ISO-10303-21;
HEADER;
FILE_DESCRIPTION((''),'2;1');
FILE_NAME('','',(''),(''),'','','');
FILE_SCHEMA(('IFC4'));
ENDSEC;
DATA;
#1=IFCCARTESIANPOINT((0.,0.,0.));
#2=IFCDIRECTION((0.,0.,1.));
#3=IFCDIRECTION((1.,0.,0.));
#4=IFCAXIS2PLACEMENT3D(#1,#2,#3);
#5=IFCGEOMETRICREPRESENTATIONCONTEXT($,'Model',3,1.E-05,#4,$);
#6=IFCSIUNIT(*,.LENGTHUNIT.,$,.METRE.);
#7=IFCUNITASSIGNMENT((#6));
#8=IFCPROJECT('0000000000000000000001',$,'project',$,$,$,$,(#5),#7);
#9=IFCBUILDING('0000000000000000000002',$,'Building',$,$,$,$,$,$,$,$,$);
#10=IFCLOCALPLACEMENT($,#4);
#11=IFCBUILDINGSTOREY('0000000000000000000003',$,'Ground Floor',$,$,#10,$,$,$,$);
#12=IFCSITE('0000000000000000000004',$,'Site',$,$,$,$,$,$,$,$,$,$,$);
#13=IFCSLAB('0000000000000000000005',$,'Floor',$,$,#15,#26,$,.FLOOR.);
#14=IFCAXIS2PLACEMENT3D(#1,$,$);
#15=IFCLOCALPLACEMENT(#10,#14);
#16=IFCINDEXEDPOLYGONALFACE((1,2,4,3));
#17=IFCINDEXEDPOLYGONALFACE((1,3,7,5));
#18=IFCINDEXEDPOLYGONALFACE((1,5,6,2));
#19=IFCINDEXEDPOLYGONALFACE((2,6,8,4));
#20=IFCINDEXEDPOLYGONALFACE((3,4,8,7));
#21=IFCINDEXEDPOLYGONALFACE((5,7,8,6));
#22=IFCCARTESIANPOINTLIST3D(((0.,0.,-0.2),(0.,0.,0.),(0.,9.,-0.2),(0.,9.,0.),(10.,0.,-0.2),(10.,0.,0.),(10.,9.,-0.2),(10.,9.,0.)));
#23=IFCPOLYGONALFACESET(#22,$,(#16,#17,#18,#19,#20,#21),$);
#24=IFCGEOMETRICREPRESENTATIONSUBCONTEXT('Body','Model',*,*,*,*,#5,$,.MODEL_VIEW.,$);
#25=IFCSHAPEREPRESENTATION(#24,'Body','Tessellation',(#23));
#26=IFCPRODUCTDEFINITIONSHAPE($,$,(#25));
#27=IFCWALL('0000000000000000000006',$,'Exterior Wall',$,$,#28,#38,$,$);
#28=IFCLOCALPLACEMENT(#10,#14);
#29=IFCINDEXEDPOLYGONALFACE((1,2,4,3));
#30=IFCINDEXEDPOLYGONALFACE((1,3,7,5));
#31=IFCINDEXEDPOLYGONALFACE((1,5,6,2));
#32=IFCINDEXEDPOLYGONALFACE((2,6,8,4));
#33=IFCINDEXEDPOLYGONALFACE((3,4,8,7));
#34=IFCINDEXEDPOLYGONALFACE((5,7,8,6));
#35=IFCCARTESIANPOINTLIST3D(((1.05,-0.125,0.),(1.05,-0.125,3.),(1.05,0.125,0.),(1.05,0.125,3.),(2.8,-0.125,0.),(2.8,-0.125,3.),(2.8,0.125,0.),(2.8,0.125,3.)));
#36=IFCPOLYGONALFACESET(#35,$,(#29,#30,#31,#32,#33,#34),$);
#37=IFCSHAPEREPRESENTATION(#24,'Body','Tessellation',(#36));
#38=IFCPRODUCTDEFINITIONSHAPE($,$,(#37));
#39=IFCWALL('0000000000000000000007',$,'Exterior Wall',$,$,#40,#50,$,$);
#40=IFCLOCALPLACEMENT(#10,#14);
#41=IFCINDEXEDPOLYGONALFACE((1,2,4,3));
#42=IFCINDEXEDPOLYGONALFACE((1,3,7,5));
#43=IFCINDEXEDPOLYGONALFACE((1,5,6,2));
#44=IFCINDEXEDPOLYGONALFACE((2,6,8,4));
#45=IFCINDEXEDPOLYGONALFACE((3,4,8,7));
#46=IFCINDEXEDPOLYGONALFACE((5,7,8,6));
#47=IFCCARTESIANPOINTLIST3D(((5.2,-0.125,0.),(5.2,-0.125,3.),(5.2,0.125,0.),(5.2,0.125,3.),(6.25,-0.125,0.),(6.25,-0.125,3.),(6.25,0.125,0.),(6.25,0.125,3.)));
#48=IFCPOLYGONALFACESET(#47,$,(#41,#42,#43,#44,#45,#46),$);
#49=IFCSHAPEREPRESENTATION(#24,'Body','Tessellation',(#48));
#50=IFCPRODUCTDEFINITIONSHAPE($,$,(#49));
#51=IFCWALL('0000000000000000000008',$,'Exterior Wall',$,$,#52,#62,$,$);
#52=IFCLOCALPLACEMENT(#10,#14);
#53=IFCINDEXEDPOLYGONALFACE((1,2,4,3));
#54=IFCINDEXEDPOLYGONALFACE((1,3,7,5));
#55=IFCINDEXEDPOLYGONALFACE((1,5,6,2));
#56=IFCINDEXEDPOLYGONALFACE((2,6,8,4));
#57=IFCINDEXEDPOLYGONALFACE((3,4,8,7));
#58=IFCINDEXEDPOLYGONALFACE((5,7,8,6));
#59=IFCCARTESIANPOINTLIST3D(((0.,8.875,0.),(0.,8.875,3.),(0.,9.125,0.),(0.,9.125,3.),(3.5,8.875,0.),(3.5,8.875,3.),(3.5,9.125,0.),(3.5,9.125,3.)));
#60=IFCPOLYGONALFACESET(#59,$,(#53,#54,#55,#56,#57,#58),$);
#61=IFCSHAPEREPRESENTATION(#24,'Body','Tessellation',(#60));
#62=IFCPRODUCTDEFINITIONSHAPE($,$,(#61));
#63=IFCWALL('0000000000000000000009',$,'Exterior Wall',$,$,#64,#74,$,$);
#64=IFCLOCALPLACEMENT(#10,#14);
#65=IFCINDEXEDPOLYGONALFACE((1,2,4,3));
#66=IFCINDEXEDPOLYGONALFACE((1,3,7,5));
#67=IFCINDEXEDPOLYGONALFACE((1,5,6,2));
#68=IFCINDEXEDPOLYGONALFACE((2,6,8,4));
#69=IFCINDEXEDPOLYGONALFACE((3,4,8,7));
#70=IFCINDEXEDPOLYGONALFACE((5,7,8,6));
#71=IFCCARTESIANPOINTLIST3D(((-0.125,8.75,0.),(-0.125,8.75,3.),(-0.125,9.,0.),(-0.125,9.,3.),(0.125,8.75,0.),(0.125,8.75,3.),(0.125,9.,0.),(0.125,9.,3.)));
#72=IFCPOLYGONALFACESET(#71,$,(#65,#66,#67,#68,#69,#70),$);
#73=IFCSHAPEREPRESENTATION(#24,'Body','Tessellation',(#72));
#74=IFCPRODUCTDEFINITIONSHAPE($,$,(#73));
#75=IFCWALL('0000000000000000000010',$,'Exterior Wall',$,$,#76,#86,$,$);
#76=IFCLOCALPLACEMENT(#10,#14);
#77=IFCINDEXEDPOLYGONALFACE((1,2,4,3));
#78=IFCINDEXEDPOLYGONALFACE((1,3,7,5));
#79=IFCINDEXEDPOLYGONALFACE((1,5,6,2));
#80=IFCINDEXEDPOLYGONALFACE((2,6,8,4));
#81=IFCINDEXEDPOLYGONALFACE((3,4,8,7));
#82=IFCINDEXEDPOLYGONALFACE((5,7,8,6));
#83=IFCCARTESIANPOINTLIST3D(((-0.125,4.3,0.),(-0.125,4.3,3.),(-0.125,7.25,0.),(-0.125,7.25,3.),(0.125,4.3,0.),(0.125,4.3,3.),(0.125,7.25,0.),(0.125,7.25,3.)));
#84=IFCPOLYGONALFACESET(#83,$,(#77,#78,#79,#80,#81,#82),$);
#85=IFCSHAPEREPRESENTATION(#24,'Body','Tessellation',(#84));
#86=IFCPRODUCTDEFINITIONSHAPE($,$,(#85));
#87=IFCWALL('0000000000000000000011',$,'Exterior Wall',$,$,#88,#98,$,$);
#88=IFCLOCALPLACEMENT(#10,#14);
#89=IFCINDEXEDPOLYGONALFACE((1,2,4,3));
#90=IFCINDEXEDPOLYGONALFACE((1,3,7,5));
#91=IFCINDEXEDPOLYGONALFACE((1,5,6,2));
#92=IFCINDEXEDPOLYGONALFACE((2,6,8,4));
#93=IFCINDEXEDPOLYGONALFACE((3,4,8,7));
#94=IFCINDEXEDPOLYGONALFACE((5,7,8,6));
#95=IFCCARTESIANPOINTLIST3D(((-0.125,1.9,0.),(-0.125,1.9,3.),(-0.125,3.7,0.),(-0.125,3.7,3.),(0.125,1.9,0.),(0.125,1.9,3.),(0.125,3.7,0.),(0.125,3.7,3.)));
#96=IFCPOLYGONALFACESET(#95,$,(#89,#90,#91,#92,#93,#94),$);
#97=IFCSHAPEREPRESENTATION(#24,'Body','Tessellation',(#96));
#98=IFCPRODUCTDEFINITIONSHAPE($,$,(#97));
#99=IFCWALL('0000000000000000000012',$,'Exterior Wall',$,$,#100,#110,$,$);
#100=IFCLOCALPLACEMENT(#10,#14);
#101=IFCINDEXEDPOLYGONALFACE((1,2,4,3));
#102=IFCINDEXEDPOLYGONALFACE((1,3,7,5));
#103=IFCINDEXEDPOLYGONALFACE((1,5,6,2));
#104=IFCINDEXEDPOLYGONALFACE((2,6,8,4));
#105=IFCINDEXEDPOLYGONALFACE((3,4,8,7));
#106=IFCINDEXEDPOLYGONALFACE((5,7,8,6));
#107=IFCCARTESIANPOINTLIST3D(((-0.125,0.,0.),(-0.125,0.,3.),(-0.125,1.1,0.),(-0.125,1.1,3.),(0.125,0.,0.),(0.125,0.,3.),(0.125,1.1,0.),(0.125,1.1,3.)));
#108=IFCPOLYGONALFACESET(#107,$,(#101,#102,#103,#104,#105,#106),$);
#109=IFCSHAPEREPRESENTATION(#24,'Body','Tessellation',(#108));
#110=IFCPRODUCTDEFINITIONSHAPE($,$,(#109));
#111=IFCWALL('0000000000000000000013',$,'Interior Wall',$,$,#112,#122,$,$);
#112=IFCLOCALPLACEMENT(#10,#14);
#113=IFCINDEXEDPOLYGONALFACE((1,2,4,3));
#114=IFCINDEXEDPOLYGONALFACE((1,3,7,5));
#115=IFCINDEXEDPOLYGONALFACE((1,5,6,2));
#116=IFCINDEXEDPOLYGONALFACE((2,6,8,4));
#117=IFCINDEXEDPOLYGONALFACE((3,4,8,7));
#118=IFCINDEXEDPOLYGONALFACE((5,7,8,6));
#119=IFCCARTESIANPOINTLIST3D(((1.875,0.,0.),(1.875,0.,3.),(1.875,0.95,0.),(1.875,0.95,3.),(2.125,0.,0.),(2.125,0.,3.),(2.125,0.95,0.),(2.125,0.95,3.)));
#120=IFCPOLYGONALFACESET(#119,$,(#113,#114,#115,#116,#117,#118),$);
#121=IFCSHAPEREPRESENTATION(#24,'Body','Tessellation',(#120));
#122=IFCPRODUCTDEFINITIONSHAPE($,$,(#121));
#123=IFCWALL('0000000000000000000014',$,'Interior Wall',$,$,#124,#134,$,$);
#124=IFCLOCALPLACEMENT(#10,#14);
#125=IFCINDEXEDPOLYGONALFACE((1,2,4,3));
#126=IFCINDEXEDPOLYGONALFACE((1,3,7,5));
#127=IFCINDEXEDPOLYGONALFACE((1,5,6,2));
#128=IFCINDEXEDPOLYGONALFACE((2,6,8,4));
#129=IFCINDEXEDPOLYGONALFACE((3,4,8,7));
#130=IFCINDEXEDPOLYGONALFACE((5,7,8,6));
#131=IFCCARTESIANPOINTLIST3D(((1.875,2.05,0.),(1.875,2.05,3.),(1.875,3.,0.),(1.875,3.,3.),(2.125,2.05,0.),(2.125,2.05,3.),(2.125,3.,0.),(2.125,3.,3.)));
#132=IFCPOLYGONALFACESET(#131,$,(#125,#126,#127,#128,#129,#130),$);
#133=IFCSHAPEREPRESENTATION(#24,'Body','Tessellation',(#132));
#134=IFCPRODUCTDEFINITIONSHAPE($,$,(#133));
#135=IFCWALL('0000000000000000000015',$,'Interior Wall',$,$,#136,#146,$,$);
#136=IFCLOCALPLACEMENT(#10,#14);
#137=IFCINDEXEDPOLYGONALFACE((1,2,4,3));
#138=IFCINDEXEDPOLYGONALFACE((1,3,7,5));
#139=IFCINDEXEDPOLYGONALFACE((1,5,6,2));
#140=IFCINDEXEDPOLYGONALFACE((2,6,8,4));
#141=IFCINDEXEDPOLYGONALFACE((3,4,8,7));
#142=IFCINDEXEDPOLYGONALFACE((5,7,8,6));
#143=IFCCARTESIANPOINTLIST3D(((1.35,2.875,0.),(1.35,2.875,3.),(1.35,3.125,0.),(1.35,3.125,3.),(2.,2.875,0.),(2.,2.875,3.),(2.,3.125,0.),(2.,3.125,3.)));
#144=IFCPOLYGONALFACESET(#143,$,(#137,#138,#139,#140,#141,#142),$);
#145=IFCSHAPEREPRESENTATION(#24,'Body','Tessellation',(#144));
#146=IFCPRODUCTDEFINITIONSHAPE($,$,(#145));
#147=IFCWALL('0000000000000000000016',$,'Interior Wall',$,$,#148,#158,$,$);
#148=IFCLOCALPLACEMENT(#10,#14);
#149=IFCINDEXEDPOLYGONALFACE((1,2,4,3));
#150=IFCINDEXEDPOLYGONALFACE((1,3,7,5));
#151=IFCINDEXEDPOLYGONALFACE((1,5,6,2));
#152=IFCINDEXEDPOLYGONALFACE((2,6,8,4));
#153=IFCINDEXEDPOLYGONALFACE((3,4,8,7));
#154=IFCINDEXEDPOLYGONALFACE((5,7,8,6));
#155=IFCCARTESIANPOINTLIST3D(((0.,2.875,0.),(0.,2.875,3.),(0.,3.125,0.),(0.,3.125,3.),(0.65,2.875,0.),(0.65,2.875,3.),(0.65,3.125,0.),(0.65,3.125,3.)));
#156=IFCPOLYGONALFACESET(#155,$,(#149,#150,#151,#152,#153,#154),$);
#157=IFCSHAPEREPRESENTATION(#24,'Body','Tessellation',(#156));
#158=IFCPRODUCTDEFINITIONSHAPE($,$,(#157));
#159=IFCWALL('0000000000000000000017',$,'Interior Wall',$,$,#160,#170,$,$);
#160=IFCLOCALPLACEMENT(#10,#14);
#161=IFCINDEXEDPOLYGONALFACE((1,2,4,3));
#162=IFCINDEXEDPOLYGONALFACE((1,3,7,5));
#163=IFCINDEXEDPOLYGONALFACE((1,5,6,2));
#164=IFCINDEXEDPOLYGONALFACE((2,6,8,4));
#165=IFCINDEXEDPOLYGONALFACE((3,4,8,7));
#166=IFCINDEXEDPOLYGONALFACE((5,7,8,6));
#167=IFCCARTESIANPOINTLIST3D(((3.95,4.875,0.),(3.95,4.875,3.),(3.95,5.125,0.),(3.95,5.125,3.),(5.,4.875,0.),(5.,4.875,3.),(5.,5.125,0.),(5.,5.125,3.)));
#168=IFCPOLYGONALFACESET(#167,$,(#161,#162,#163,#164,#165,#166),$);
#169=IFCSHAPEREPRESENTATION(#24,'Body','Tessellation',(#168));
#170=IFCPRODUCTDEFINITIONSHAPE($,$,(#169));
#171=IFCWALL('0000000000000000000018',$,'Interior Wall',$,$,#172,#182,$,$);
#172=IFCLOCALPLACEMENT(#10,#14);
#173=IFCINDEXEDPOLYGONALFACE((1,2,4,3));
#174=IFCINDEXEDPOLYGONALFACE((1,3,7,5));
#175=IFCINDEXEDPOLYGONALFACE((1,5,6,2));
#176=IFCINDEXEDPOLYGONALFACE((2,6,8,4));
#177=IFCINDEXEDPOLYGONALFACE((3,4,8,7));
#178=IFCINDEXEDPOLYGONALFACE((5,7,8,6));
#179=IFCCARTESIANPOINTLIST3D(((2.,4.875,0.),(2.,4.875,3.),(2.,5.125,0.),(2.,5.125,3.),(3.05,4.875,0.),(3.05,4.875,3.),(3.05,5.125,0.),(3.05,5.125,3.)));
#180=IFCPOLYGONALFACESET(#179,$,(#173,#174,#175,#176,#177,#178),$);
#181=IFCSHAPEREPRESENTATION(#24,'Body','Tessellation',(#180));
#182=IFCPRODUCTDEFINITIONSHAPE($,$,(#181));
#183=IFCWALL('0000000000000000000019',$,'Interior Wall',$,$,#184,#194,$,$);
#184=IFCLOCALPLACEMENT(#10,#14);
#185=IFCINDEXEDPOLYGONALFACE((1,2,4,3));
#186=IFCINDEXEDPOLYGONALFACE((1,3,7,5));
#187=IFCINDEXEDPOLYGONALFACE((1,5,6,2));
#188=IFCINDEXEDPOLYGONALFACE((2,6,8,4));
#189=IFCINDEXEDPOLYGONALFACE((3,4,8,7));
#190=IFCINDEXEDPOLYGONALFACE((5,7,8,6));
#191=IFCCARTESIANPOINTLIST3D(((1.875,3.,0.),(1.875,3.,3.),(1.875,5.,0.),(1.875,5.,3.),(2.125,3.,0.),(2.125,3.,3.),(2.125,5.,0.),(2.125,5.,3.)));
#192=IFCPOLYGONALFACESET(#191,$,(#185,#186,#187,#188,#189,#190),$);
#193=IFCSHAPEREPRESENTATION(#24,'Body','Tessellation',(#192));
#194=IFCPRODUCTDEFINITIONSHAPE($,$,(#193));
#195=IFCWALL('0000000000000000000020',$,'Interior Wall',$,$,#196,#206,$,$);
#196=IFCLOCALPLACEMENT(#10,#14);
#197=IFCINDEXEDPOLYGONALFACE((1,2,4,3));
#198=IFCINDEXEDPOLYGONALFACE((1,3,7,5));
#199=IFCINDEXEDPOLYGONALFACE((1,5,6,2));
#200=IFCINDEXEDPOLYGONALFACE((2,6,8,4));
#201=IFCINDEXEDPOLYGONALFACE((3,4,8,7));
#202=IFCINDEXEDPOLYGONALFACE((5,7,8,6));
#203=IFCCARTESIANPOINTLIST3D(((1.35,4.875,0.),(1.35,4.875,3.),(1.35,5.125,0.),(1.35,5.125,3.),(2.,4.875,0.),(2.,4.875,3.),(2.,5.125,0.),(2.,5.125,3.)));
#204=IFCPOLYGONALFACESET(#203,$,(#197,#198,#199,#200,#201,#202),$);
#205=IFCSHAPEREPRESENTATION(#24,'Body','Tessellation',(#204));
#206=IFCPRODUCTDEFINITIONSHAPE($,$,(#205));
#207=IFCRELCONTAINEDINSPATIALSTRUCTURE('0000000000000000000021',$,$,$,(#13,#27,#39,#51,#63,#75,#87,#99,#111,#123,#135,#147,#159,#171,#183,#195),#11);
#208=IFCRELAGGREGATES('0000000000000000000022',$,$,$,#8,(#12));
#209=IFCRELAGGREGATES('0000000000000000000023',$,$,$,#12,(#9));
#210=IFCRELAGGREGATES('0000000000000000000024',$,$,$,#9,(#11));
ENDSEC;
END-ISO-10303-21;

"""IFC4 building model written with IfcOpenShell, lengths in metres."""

from ifc_helpers import new_model, si_unit, frame, origin_with_axes, place, context, subcontext, project, spatial, indexed_curve, outline, extrude, element, save


model = new_model("IFC4")

# Units and contexts
model_context = context("Model", 3, precision=1e-05, world=origin_with_axes())
body_context = subcontext(model_context, "Body", "Model", "MODEL_VIEW")
ifc_project = project(units=[si_unit("LENGTHUNIT", "METRE")], contexts=[model_context])

# Site, building, storey
site = spatial("IfcSite", under=ifc_project, Name="Site")
building = spatial("IfcBuilding", under=site, Name="Building")
storey_placement = place(None, origin_with_axes())
storey = spatial("IfcBuildingStorey", under=building, at=storey_placement, Name="Ground Floor")

# Slab
slab_placement = place(storey_placement, frame((0.0, 0.0, -0.2), z_axis=(0.0, 0.0, 1.0), x_axis=(1.0, 0.0, 0.0)))
element("IfcSlab", 1, at=slab_placement, inside=storey, Name="Floor", PredefinedType="FLOOR", context=body_context, shape_type="SweptSolid", body=[
    extrude(outline(indexed_curve([(0.0, 0.0), (10.0, 0.0), (10.0, 9.0), (0.0, 9.0)])), None, (0.0, 0.0, 1.0), 0.2),
])

# Walls
wall_1_placement = place(storey_placement, frame((1.05, 0.0, 0.0), z_axis=(0.0, 0.0, 1.0), x_axis=(1.0, 0.0, 0.0)))
element("IfcWall", 2, at=wall_1_placement, inside=storey, Name="Exterior Wall", context=body_context, shape_type="SweptSolid", body=[
    extrude(outline(indexed_curve([(0.0, 0.0), (0.0, 0.25), (1.75, 0.25), (1.75, 0.0), (0.0, 0.0)], self_intersect=False)), frame((0.0, -0.125, 0.0), z_axis=(0.0, 0.0, 1.0), x_axis=(1.0, 0.0, 0.0)), (0.0, 0.0, 1.0), 3.0),
])
wall_2_placement = place(storey_placement, frame((5.2, 0.0, 0.0), z_axis=(0.0, 0.0, 1.0), x_axis=(1.0, 0.0, 0.0)))
element("IfcWall", 3, at=wall_2_placement, inside=storey, Name="Exterior Wall", context=body_context, shape_type="SweptSolid", body=[
    extrude(outline(indexed_curve([(0.0, 0.0), (0.0, 0.25), (1.05, 0.25), (1.05, 0.0), (0.0, 0.0)], self_intersect=False)), frame((0.0, -0.125, 0.0), z_axis=(0.0, 0.0, 1.0), x_axis=(1.0, 0.0, 0.0)), (0.0, 0.0, 1.0), 3.0),
])
wall_3_placement = place(storey_placement, frame((3.5, 9.0, 0.0), z_axis=(0.0, 0.0, 1.0), x_axis=(-1.0, 0.0, 0.0)))
element("IfcWall", 4, at=wall_3_placement, inside=storey, Name="Exterior Wall", context=body_context, shape_type="SweptSolid", body=[
    extrude(outline(indexed_curve([(0.0, 0.0), (0.0, 0.25), (3.5, 0.25), (3.5, 0.0), (0.0, 0.0)], self_intersect=False)), frame((0.0, -0.125, 0.0), z_axis=(0.0, 0.0, 1.0), x_axis=(1.0, 0.0, 0.0)), (0.0, 0.0, 1.0), 3.0),
])
wall_4_placement = place(storey_placement, frame((0.0, 9.0, 0.0), z_axis=(0.0, 0.0, 1.0), x_axis=(0.0, -1.0, 0.0)))
element("IfcWall", 5, at=wall_4_placement, inside=storey, Name="Exterior Wall", context=body_context, shape_type="SweptSolid", body=[
    extrude(outline(indexed_curve([(0.0, 0.0), (0.0, 0.25), (0.25, 0.25), (0.25, 0.0), (0.0, 0.0)], self_intersect=False)), frame((0.0, -0.125, 0.0), z_axis=(0.0, 0.0, 1.0), x_axis=(1.0, 0.0, 0.0)), (0.0, 0.0, 1.0), 3.0),
])
wall_5_placement = place(storey_placement, frame((0.0, 7.25, 0.0), z_axis=(0.0, 0.0, 1.0), x_axis=(0.0, -1.0, 0.0)))
element("IfcWall", 6, at=wall_5_placement, inside=storey, Name="Exterior Wall", context=body_context, shape_type="SweptSolid", body=[
    extrude(outline(indexed_curve([(0.0, 0.0), (0.0, 0.25), (2.95, 0.25), (2.95, 0.0), (0.0, 0.0)], self_intersect=False)), frame((0.0, -0.125, 0.0), z_axis=(0.0, 0.0, 1.0), x_axis=(1.0, 0.0, 0.0)), (0.0, 0.0, 1.0), 3.0),
])
wall_6_placement = place(storey_placement, frame((0.0, 3.7, 0.0), z_axis=(0.0, 0.0, 1.0), x_axis=(0.0, -1.0, 0.0)))
element("IfcWall", 7, at=wall_6_placement, inside=storey, Name="Exterior Wall", context=body_context, shape_type="SweptSolid", body=[
    extrude(outline(indexed_curve([(0.0, 0.0), (0.0, 0.25), (1.8, 0.25), (1.8, 0.0), (0.0, 0.0)], self_intersect=False)), frame((0.0, -0.125, 0.0), z_axis=(0.0, 0.0, 1.0), x_axis=(1.0, 0.0, 0.0)), (0.0, 0.0, 1.0), 3.0),
])
wall_7_placement = place(storey_placement, frame((0.0, 1.1, 0.0), z_axis=(0.0, 0.0, 1.0), x_axis=(0.0, -1.0, 0.0)))
element("IfcWall", 8, at=wall_7_placement, inside=storey, Name="Exterior Wall", context=body_context, shape_type="SweptSolid", body=[
    extrude(outline(indexed_curve([(0.0, 0.0), (0.0, 0.25), (1.1, 0.25), (1.1, 0.0), (0.0, 0.0)], self_intersect=False)), frame((0.0, -0.125, 0.0), z_axis=(0.0, 0.0, 1.0), x_axis=(1.0, 0.0, 0.0)), (0.0, 0.0, 1.0), 3.0),
])
wall_8_placement = place(storey_placement, frame((2.0, 0.0, 0.0), z_axis=(0.0, 0.0, 1.0), x_axis=(0.0, 1.0, 0.0)))
element("IfcWall", 9, at=wall_8_placement, inside=storey, Name="Interior Wall", context=body_context, shape_type="SweptSolid", body=[
    extrude(outline(indexed_curve([(0.0, 0.0), (0.0, 0.25), (0.95, 0.25), (0.95, 0.0), (0.0, 0.0)], self_intersect=False)), frame((0.0, -0.125, 0.0), z_axis=(0.0, 0.0, 1.0), x_axis=(1.0, 0.0, 0.0)), (0.0, 0.0, 1.0), 3.0),
])
wall_9_placement = place(storey_placement, frame((2.0, 2.05, 0.0), z_axis=(0.0, 0.0, 1.0), x_axis=(0.0, 1.0, 0.0)))
element("IfcWall", 10, at=wall_9_placement, inside=storey, Name="Interior Wall", context=body_context, shape_type="SweptSolid", body=[
    extrude(outline(indexed_curve([(0.0, 0.0), (0.0, 0.25), (0.95, 0.25), (0.95, 0.0), (0.0, 0.0)], self_intersect=False)), frame((0.0, -0.125, 0.0), z_axis=(0.0, 0.0, 1.0), x_axis=(1.0, 0.0, 0.0)), (0.0, 0.0, 1.0), 3.0),
])
for number, where, z_axis, x_axis, name in (
    (11, (2.0, 3.0, 0.0), (0.0, 0.0, 1.0), (-1.0, 0.0, 0.0), "Interior Wall"),
    (12, (0.65, 3.0, 0.0), (0.0, 0.0, 1.0), (-1.0, 0.0, 0.0), "Interior Wall"),
):
    element("IfcWall", number, at=place(storey_placement, frame(where, z_axis=z_axis, x_axis=x_axis)), inside=storey, Name=name, context=body_context, shape_type="SweptSolid", body=[
        extrude(outline(indexed_curve([(0.0, 0.0), (0.0, 0.25), (0.65, 0.25), (0.65, 0.0), (0.0, 0.0)], self_intersect=False)), frame((0.0, -0.125, 0.0), z_axis=(0.0, 0.0, 1.0), x_axis=(1.0, 0.0, 0.0)), (0.0, 0.0, 1.0), 3.0),
    ])
for number, where, z_axis, x_axis, name in (
    (13, (5.0, 5.0, 0.0), (0.0, 0.0, 1.0), (-1.0, 0.0, 0.0), "Interior Wall"),
    (14, (3.05, 5.0, 0.0), (0.0, 0.0, 1.0), (-1.0, 0.0, 0.0), "Interior Wall"),
):
    element("IfcWall", number, at=place(storey_placement, frame(where, z_axis=z_axis, x_axis=x_axis)), inside=storey, Name=name, context=body_context, shape_type="SweptSolid", body=[
        extrude(outline(indexed_curve([(0.0, 0.0), (0.0, 0.25), (1.05, 0.25), (1.05, 0.0), (0.0, 0.0)], self_intersect=False)), frame((0.0, -0.125, 0.0), z_axis=(0.0, 0.0, 1.0), x_axis=(1.0, 0.0, 0.0)), (0.0, 0.0, 1.0), 3.0),
    ])
wall_10_placement = place(storey_placement, frame((2.0, 5.0, 0.0), z_axis=(0.0, 0.0, 1.0), x_axis=(0.0, -1.0, 0.0)))
element("IfcWall", 15, at=wall_10_placement, inside=storey, Name="Interior Wall", context=body_context, shape_type="SweptSolid", body=[
    extrude(outline(indexed_curve([(0.0, 0.0), (0.0, 0.25), (2.0, 0.25), (2.0, 0.0), (0.0, 0.0)], self_intersect=False)), frame((0.0, -0.125, 0.0), z_axis=(0.0, 0.0, 1.0), x_axis=(1.0, 0.0, 0.0)), (0.0, 0.0, 1.0), 3.0),
])
for number, where, z_axis, x_axis, name in (
    (16, (2.0, 5.0, 0.0), (0.0, 0.0, 1.0), (-1.0, 0.0, 0.0), "Interior Wall"),
):
    element("IfcWall", number, at=place(storey_placement, frame(where, z_axis=z_axis, x_axis=x_axis)), inside=storey, Name=name, context=body_context, shape_type="SweptSolid", body=[
        extrude(outline(indexed_curve([(0.0, 0.0), (0.0, 0.25), (0.65, 0.25), (0.65, 0.0), (0.0, 0.0)], self_intersect=False)), frame((0.0, -0.125, 0.0), z_axis=(0.0, 0.0, 1.0), x_axis=(1.0, 0.0, 0.0)), (0.0, 0.0, 1.0), 3.0),
    ])

save(model, "model.ifc")
